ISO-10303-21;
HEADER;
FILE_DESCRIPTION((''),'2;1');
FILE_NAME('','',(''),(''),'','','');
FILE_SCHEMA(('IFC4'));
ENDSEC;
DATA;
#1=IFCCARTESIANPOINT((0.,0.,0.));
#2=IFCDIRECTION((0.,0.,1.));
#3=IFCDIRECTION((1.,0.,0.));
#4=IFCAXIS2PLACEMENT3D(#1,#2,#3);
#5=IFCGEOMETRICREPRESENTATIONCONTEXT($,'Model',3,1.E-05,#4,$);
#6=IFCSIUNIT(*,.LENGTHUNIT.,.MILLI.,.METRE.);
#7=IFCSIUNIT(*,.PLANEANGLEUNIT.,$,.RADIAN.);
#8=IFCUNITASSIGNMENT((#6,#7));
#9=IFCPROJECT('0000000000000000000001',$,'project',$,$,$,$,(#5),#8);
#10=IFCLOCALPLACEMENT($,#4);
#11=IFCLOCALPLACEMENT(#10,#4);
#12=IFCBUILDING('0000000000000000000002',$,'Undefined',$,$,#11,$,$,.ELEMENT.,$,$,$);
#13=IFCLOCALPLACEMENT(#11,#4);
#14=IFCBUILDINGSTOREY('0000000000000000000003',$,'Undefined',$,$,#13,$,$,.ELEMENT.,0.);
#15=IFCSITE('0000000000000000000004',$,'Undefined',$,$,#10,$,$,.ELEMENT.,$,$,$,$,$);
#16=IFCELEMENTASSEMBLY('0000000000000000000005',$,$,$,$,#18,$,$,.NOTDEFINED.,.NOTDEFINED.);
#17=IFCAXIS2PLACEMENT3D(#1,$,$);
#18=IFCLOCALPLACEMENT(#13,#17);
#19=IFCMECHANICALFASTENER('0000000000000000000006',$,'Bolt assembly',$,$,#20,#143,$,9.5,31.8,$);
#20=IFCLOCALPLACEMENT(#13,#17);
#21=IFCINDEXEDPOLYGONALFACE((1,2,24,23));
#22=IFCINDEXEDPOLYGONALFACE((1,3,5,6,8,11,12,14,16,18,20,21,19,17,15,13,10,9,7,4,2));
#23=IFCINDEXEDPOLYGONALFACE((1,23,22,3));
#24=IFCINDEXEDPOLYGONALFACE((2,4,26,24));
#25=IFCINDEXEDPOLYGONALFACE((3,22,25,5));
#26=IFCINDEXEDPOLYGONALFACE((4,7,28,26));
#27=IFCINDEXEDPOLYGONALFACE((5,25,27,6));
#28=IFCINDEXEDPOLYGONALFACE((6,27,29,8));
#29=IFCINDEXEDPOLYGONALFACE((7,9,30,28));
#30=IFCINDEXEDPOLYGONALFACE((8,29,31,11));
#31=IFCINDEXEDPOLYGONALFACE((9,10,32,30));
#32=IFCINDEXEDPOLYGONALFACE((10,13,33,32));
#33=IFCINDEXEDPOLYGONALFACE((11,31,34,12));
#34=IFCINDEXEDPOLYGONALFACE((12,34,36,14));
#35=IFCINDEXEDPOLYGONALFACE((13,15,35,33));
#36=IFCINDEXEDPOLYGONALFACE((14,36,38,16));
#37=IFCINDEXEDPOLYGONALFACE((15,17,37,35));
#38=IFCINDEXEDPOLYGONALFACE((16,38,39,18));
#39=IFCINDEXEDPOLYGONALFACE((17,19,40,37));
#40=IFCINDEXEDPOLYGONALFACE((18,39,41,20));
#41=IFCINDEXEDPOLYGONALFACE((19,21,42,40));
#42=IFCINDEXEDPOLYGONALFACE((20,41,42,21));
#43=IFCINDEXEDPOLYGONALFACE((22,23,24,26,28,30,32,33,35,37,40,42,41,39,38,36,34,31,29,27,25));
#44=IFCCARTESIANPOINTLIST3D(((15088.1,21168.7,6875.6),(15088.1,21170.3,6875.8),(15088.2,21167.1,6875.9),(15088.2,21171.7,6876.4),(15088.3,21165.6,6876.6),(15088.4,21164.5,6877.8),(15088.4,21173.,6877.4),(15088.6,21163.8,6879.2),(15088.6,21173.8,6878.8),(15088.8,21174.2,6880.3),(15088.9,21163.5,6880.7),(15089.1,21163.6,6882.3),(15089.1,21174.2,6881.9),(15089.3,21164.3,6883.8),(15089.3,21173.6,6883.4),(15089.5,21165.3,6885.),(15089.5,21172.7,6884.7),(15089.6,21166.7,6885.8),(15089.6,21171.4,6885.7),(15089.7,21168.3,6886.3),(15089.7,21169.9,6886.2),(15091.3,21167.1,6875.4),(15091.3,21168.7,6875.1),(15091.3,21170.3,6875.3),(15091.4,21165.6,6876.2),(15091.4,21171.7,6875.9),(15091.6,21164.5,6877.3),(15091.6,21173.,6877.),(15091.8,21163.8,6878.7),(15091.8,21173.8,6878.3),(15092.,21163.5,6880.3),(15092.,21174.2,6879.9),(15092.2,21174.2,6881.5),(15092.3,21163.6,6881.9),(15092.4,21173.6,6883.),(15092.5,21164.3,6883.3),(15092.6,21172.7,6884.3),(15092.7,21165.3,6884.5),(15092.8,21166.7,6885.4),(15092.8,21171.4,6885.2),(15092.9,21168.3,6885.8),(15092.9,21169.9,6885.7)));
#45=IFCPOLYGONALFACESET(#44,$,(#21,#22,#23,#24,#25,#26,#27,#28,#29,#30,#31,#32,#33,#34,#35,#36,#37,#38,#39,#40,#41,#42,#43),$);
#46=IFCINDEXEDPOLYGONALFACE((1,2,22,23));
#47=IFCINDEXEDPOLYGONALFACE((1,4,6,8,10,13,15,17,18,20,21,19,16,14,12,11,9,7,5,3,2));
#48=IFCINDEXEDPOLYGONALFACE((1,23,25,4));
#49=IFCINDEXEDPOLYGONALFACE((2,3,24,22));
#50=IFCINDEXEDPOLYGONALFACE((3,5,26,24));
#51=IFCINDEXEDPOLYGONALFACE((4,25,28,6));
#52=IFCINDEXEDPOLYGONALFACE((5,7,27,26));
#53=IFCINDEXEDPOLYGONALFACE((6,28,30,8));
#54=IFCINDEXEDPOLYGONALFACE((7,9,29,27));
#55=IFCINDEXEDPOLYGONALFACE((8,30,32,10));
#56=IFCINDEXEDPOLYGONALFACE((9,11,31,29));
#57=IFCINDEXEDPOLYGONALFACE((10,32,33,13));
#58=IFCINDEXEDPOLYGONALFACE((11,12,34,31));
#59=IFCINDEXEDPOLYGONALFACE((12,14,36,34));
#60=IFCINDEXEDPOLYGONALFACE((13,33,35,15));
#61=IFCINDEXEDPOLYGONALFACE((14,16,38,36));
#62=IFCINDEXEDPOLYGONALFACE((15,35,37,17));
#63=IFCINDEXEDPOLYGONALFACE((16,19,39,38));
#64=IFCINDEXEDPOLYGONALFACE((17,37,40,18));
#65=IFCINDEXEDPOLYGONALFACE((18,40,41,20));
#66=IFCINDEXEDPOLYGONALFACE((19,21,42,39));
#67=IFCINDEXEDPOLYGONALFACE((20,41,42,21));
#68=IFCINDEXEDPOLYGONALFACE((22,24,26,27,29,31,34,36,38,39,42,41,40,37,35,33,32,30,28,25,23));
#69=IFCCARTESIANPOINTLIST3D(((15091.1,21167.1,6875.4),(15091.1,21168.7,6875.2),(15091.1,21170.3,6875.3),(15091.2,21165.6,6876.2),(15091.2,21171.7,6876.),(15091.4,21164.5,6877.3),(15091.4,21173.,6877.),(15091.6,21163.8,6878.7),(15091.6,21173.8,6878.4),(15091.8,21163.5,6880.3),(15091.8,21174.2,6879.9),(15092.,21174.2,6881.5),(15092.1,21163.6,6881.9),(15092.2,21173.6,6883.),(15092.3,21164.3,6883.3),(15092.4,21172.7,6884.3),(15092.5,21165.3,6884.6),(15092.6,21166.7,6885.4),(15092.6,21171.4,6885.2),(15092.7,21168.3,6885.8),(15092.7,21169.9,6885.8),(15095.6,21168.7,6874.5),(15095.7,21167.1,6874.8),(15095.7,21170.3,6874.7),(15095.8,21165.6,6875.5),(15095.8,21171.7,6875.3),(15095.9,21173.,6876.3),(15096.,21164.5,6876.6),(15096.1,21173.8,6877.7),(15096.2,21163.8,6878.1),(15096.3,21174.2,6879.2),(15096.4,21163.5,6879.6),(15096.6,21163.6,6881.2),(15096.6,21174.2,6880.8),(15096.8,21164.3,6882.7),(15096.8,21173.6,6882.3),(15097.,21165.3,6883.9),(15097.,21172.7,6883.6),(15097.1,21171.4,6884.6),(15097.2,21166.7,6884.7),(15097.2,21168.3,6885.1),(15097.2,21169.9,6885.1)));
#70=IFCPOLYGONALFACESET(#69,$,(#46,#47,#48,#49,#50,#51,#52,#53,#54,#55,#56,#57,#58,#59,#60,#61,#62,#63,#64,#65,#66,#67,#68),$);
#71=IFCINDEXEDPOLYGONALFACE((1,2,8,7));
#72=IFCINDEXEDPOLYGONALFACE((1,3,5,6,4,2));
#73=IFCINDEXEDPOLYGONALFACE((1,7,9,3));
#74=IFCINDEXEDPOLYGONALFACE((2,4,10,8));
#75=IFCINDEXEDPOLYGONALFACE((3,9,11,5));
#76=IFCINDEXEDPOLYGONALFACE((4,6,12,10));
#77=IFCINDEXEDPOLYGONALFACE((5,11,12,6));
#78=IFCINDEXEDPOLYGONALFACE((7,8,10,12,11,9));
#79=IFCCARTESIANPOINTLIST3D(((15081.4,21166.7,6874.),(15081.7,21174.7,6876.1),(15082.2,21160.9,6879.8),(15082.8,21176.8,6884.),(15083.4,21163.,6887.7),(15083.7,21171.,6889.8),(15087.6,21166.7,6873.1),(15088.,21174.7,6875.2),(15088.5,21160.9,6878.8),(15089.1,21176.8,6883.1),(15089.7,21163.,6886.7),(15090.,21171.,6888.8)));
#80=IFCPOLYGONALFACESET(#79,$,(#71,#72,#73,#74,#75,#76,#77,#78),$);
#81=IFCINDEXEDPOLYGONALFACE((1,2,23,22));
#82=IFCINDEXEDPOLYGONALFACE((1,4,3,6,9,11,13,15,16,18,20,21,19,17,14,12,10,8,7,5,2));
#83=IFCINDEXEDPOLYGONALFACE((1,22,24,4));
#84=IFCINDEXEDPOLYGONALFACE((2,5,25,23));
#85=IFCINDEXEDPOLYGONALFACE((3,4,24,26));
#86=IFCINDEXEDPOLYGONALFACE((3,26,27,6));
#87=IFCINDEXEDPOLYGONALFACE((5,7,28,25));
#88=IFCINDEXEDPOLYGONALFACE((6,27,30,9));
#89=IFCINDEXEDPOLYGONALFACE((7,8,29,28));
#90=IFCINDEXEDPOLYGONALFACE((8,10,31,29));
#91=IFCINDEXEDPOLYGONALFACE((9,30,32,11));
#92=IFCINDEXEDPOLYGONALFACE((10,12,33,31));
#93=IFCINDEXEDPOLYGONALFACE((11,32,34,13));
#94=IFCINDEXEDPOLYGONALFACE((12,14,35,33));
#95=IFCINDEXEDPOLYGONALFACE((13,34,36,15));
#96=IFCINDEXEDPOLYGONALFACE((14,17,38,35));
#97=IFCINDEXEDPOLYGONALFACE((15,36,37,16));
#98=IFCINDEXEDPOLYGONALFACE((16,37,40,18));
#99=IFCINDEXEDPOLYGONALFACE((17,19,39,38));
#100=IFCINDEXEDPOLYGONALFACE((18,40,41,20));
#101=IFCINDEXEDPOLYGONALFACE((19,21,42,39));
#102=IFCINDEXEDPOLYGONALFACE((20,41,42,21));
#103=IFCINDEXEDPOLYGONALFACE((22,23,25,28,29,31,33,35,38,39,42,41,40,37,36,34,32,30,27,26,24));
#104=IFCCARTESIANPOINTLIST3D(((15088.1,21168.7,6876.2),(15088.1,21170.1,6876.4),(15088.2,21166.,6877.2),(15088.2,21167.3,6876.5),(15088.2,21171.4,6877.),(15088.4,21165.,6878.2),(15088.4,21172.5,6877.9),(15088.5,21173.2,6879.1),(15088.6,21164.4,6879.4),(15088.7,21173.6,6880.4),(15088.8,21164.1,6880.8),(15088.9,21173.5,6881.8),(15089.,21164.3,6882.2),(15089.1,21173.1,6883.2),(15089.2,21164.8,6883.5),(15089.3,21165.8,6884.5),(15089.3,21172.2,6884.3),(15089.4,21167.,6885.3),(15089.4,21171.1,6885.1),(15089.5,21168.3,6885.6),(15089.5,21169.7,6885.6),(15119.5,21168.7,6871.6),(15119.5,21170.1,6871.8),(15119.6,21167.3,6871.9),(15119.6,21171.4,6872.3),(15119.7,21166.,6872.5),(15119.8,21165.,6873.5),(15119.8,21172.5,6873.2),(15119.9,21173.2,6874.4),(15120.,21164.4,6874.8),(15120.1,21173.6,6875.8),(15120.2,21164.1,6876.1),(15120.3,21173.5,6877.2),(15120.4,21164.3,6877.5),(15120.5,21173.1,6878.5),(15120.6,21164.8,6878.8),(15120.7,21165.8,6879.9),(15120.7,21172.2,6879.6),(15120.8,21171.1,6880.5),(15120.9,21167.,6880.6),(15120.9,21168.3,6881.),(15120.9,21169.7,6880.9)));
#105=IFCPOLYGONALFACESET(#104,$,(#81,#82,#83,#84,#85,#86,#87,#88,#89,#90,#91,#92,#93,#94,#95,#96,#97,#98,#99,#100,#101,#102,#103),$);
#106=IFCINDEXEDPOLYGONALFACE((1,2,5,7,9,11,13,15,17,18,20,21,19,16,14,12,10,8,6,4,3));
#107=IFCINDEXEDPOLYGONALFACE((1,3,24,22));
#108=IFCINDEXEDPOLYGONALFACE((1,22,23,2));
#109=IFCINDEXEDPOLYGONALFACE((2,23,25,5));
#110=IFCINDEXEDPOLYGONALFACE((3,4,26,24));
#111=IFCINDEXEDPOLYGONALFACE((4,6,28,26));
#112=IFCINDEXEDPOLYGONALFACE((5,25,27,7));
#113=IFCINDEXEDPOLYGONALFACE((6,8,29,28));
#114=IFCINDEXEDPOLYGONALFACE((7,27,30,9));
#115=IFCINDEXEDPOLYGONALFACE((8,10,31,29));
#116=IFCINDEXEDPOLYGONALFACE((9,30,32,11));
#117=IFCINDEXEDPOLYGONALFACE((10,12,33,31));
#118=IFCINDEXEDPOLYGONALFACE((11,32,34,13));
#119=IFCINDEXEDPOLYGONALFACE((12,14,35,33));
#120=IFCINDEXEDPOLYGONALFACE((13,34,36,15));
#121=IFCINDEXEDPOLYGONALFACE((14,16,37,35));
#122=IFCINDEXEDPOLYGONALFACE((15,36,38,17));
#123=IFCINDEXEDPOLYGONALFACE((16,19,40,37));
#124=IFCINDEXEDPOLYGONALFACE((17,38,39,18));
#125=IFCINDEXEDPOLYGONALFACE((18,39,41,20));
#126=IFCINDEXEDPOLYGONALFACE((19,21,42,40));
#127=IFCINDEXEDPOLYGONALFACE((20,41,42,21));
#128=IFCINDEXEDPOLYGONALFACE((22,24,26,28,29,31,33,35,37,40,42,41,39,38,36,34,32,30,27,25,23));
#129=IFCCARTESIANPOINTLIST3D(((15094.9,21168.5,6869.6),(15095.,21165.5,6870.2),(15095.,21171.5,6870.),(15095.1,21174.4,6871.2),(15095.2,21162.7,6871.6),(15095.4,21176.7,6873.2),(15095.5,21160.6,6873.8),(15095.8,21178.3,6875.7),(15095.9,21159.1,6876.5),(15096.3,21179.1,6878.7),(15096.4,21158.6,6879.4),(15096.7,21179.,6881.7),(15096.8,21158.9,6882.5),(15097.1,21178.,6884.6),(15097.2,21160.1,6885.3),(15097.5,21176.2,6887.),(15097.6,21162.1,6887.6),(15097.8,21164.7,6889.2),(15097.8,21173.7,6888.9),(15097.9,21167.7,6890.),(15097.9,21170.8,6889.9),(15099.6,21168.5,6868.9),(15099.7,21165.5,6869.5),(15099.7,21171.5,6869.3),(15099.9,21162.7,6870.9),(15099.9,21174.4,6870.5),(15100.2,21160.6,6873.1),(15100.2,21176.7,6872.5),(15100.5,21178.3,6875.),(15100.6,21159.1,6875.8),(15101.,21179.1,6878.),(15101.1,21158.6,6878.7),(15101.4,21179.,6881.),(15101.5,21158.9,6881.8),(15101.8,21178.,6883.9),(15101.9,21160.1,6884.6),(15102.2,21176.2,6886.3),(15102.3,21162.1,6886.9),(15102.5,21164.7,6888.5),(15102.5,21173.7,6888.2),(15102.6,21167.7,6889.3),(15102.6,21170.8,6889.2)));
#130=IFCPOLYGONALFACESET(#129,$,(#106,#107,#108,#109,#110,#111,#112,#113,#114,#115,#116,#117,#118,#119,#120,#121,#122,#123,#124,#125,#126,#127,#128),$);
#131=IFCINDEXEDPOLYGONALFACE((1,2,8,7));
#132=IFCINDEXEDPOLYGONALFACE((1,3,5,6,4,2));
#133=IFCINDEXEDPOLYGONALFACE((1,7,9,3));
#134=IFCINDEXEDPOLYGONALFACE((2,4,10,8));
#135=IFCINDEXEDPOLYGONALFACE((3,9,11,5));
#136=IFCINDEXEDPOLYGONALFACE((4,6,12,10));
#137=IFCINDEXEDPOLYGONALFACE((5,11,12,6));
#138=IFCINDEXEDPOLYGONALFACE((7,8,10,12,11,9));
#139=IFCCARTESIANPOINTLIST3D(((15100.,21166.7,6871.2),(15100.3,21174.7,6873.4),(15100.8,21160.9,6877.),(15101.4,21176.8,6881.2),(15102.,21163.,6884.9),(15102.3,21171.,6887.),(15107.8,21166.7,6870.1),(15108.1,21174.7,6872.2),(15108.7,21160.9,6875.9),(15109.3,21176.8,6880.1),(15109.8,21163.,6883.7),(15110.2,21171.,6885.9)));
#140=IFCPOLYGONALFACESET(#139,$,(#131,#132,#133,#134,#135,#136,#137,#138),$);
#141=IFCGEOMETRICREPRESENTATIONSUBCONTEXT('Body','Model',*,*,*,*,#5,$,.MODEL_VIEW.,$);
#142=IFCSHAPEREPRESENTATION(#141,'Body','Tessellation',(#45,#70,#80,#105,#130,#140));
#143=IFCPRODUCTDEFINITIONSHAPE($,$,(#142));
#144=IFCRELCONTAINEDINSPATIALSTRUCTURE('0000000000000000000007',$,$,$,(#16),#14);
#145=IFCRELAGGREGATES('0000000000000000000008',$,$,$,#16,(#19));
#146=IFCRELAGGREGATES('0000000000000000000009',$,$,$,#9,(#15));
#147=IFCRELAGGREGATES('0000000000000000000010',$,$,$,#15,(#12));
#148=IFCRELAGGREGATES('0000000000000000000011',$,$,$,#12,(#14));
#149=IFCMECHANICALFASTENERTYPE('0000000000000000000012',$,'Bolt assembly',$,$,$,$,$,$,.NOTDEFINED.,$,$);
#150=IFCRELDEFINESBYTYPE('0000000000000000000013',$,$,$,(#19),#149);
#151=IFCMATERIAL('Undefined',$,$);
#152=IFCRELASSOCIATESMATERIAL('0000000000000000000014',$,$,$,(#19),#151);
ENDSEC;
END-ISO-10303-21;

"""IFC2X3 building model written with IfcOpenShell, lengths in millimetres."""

from ifc_helpers import new_model, si_unit, frame, origin_with_axes, origin_2d_with_axis, place, context, subcontext, project, spatial, polyline, circle, outline, extrude, source, transform, mapped, material, type_object, element, aggregate, save


model = new_model("IFC2X3")

# Units and contexts
model_context = context("Model", 3, precision=1e-05, world=origin_with_axes())
body_context = subcontext(model_context, "Body", "Model", "MODEL_VIEW")
ifc_project = project(units=[si_unit("LENGTHUNIT", "METRE", prefix="MILLI"), si_unit("PLANEANGLEUNIT", "RADIAN")], contexts=[model_context])

# Site, building, storey
site_placement = place(None, origin_with_axes())
site = spatial("IfcSite", under=ifc_project, at=site_placement, Name="Undefined", CompositionType="ELEMENT")
building_placement = place(site_placement, origin_with_axes())
building = spatial("IfcBuilding", under=site, at=building_placement, Name="Undefined", CompositionType="ELEMENT")
storey_placement = place(building_placement, origin_with_axes())
storey = spatial("IfcBuildingStorey", under=building, at=storey_placement, Name="Undefined", CompositionType="ELEMENT", Elevation=0.0)

# Element assembly
assembly_1_placement = place(storey_placement, origin_with_axes())
assembly_1 = element("IfcElementAssembly", 1, at=assembly_1_placement, inside=storey, AssemblyPlace="NOTDEFINED", PredefinedType="NOTDEFINED")

# Shared definitions
ifc_material_1 = material(Name="Undefined")
mechanical_fastener_type = type_object("IfcMechanicalFastenerType", Name="Bolt assembly")

# Mechanical fastener
shared_shape_1 = source(origin_with_axes(), body_context, "Body", "SweptSolid", [
    extrude(circle(Radius=5.4, at=origin_2d_with_axis()), frame((0.0, -3.1, 0.0), z_axis=(0.0, 1.0, 0.0), x_axis=(1.0, 0.0, 0.0)), (0.0, 0.0, 1.0), 3.2),
    extrude(circle(Radius=5.4, at=origin_2d_with_axis()), frame((0.0, -0.1, 0.0), z_axis=(0.0, 1.0, 0.0), x_axis=(1.0, 0.0, 0.0)), (0.0, 0.0, 1.0), 4.6),
    extrude(outline(polyline([(7.1, -4.1), (7.1, 4.1), (0.0, 8.2), (-7.1, 4.1), (-7.1, -4.1), (0.0, -8.2), (7.1, -4.1)])), frame((0.0, -9.6, 0.0), z_axis=(0.0, 1.0, 0.0), x_axis=(1.0, 0.0, 0.0)), (0.0, 0.0, 1.0), 6.3),
    extrude(circle(Radius=4.8, at=origin_2d_with_axis()), frame((0.0, -3.2, 0.0), z_axis=(0.0, 1.0, 0.0), x_axis=(1.0, 0.0, 0.0)), (0.0, 0.0, 1.0), 31.8),
    extrude(circle(Radius=10.3, at=origin_2d_with_axis()), frame((0.0, 4.5, 0.0), z_axis=(0.0, 1.0, 0.0), x_axis=(1.0, 0.0, 0.0)), (0.0, 0.0, 1.0), 4.8),
    extrude(outline(polyline([(7.1, -4.1), (7.1, 4.1), (0.0, 8.2), (-7.1, 4.1), (-7.1, -4.1), (0.0, -8.2), (7.1, -4.1)])), frame((0.0, 9.3, 0.0), z_axis=(0.0, 1.0, 0.0), x_axis=(1.0, 0.0, 0.0)), (0.0, 0.0, 1.0), 7.9),
])
mechanical_fastener_1_placement = place(assembly_1_placement, frame((15092.0, 21168.9, 6880.5), z_axis=(-0.10338, 0.707107, -0.699509), x_axis=(0.10338, 0.707107, 0.699509)))
mechanical_fastener_1 = element("IfcMechanicalFastener", 2, at=mechanical_fastener_1_placement, type_object=mechanical_fastener_type, material=ifc_material_1, Name="Bolt assembly", NominalDiameter=9.5, NominalLength=31.8, context=body_context, shape_type="MappedRepresentation", body=[
    mapped(shared_shape_1, transform((0.0, 0.0, 0.0))),
])
aggregate(assembly_1, [mechanical_fastener_1])

save(model, "model.ifc")
